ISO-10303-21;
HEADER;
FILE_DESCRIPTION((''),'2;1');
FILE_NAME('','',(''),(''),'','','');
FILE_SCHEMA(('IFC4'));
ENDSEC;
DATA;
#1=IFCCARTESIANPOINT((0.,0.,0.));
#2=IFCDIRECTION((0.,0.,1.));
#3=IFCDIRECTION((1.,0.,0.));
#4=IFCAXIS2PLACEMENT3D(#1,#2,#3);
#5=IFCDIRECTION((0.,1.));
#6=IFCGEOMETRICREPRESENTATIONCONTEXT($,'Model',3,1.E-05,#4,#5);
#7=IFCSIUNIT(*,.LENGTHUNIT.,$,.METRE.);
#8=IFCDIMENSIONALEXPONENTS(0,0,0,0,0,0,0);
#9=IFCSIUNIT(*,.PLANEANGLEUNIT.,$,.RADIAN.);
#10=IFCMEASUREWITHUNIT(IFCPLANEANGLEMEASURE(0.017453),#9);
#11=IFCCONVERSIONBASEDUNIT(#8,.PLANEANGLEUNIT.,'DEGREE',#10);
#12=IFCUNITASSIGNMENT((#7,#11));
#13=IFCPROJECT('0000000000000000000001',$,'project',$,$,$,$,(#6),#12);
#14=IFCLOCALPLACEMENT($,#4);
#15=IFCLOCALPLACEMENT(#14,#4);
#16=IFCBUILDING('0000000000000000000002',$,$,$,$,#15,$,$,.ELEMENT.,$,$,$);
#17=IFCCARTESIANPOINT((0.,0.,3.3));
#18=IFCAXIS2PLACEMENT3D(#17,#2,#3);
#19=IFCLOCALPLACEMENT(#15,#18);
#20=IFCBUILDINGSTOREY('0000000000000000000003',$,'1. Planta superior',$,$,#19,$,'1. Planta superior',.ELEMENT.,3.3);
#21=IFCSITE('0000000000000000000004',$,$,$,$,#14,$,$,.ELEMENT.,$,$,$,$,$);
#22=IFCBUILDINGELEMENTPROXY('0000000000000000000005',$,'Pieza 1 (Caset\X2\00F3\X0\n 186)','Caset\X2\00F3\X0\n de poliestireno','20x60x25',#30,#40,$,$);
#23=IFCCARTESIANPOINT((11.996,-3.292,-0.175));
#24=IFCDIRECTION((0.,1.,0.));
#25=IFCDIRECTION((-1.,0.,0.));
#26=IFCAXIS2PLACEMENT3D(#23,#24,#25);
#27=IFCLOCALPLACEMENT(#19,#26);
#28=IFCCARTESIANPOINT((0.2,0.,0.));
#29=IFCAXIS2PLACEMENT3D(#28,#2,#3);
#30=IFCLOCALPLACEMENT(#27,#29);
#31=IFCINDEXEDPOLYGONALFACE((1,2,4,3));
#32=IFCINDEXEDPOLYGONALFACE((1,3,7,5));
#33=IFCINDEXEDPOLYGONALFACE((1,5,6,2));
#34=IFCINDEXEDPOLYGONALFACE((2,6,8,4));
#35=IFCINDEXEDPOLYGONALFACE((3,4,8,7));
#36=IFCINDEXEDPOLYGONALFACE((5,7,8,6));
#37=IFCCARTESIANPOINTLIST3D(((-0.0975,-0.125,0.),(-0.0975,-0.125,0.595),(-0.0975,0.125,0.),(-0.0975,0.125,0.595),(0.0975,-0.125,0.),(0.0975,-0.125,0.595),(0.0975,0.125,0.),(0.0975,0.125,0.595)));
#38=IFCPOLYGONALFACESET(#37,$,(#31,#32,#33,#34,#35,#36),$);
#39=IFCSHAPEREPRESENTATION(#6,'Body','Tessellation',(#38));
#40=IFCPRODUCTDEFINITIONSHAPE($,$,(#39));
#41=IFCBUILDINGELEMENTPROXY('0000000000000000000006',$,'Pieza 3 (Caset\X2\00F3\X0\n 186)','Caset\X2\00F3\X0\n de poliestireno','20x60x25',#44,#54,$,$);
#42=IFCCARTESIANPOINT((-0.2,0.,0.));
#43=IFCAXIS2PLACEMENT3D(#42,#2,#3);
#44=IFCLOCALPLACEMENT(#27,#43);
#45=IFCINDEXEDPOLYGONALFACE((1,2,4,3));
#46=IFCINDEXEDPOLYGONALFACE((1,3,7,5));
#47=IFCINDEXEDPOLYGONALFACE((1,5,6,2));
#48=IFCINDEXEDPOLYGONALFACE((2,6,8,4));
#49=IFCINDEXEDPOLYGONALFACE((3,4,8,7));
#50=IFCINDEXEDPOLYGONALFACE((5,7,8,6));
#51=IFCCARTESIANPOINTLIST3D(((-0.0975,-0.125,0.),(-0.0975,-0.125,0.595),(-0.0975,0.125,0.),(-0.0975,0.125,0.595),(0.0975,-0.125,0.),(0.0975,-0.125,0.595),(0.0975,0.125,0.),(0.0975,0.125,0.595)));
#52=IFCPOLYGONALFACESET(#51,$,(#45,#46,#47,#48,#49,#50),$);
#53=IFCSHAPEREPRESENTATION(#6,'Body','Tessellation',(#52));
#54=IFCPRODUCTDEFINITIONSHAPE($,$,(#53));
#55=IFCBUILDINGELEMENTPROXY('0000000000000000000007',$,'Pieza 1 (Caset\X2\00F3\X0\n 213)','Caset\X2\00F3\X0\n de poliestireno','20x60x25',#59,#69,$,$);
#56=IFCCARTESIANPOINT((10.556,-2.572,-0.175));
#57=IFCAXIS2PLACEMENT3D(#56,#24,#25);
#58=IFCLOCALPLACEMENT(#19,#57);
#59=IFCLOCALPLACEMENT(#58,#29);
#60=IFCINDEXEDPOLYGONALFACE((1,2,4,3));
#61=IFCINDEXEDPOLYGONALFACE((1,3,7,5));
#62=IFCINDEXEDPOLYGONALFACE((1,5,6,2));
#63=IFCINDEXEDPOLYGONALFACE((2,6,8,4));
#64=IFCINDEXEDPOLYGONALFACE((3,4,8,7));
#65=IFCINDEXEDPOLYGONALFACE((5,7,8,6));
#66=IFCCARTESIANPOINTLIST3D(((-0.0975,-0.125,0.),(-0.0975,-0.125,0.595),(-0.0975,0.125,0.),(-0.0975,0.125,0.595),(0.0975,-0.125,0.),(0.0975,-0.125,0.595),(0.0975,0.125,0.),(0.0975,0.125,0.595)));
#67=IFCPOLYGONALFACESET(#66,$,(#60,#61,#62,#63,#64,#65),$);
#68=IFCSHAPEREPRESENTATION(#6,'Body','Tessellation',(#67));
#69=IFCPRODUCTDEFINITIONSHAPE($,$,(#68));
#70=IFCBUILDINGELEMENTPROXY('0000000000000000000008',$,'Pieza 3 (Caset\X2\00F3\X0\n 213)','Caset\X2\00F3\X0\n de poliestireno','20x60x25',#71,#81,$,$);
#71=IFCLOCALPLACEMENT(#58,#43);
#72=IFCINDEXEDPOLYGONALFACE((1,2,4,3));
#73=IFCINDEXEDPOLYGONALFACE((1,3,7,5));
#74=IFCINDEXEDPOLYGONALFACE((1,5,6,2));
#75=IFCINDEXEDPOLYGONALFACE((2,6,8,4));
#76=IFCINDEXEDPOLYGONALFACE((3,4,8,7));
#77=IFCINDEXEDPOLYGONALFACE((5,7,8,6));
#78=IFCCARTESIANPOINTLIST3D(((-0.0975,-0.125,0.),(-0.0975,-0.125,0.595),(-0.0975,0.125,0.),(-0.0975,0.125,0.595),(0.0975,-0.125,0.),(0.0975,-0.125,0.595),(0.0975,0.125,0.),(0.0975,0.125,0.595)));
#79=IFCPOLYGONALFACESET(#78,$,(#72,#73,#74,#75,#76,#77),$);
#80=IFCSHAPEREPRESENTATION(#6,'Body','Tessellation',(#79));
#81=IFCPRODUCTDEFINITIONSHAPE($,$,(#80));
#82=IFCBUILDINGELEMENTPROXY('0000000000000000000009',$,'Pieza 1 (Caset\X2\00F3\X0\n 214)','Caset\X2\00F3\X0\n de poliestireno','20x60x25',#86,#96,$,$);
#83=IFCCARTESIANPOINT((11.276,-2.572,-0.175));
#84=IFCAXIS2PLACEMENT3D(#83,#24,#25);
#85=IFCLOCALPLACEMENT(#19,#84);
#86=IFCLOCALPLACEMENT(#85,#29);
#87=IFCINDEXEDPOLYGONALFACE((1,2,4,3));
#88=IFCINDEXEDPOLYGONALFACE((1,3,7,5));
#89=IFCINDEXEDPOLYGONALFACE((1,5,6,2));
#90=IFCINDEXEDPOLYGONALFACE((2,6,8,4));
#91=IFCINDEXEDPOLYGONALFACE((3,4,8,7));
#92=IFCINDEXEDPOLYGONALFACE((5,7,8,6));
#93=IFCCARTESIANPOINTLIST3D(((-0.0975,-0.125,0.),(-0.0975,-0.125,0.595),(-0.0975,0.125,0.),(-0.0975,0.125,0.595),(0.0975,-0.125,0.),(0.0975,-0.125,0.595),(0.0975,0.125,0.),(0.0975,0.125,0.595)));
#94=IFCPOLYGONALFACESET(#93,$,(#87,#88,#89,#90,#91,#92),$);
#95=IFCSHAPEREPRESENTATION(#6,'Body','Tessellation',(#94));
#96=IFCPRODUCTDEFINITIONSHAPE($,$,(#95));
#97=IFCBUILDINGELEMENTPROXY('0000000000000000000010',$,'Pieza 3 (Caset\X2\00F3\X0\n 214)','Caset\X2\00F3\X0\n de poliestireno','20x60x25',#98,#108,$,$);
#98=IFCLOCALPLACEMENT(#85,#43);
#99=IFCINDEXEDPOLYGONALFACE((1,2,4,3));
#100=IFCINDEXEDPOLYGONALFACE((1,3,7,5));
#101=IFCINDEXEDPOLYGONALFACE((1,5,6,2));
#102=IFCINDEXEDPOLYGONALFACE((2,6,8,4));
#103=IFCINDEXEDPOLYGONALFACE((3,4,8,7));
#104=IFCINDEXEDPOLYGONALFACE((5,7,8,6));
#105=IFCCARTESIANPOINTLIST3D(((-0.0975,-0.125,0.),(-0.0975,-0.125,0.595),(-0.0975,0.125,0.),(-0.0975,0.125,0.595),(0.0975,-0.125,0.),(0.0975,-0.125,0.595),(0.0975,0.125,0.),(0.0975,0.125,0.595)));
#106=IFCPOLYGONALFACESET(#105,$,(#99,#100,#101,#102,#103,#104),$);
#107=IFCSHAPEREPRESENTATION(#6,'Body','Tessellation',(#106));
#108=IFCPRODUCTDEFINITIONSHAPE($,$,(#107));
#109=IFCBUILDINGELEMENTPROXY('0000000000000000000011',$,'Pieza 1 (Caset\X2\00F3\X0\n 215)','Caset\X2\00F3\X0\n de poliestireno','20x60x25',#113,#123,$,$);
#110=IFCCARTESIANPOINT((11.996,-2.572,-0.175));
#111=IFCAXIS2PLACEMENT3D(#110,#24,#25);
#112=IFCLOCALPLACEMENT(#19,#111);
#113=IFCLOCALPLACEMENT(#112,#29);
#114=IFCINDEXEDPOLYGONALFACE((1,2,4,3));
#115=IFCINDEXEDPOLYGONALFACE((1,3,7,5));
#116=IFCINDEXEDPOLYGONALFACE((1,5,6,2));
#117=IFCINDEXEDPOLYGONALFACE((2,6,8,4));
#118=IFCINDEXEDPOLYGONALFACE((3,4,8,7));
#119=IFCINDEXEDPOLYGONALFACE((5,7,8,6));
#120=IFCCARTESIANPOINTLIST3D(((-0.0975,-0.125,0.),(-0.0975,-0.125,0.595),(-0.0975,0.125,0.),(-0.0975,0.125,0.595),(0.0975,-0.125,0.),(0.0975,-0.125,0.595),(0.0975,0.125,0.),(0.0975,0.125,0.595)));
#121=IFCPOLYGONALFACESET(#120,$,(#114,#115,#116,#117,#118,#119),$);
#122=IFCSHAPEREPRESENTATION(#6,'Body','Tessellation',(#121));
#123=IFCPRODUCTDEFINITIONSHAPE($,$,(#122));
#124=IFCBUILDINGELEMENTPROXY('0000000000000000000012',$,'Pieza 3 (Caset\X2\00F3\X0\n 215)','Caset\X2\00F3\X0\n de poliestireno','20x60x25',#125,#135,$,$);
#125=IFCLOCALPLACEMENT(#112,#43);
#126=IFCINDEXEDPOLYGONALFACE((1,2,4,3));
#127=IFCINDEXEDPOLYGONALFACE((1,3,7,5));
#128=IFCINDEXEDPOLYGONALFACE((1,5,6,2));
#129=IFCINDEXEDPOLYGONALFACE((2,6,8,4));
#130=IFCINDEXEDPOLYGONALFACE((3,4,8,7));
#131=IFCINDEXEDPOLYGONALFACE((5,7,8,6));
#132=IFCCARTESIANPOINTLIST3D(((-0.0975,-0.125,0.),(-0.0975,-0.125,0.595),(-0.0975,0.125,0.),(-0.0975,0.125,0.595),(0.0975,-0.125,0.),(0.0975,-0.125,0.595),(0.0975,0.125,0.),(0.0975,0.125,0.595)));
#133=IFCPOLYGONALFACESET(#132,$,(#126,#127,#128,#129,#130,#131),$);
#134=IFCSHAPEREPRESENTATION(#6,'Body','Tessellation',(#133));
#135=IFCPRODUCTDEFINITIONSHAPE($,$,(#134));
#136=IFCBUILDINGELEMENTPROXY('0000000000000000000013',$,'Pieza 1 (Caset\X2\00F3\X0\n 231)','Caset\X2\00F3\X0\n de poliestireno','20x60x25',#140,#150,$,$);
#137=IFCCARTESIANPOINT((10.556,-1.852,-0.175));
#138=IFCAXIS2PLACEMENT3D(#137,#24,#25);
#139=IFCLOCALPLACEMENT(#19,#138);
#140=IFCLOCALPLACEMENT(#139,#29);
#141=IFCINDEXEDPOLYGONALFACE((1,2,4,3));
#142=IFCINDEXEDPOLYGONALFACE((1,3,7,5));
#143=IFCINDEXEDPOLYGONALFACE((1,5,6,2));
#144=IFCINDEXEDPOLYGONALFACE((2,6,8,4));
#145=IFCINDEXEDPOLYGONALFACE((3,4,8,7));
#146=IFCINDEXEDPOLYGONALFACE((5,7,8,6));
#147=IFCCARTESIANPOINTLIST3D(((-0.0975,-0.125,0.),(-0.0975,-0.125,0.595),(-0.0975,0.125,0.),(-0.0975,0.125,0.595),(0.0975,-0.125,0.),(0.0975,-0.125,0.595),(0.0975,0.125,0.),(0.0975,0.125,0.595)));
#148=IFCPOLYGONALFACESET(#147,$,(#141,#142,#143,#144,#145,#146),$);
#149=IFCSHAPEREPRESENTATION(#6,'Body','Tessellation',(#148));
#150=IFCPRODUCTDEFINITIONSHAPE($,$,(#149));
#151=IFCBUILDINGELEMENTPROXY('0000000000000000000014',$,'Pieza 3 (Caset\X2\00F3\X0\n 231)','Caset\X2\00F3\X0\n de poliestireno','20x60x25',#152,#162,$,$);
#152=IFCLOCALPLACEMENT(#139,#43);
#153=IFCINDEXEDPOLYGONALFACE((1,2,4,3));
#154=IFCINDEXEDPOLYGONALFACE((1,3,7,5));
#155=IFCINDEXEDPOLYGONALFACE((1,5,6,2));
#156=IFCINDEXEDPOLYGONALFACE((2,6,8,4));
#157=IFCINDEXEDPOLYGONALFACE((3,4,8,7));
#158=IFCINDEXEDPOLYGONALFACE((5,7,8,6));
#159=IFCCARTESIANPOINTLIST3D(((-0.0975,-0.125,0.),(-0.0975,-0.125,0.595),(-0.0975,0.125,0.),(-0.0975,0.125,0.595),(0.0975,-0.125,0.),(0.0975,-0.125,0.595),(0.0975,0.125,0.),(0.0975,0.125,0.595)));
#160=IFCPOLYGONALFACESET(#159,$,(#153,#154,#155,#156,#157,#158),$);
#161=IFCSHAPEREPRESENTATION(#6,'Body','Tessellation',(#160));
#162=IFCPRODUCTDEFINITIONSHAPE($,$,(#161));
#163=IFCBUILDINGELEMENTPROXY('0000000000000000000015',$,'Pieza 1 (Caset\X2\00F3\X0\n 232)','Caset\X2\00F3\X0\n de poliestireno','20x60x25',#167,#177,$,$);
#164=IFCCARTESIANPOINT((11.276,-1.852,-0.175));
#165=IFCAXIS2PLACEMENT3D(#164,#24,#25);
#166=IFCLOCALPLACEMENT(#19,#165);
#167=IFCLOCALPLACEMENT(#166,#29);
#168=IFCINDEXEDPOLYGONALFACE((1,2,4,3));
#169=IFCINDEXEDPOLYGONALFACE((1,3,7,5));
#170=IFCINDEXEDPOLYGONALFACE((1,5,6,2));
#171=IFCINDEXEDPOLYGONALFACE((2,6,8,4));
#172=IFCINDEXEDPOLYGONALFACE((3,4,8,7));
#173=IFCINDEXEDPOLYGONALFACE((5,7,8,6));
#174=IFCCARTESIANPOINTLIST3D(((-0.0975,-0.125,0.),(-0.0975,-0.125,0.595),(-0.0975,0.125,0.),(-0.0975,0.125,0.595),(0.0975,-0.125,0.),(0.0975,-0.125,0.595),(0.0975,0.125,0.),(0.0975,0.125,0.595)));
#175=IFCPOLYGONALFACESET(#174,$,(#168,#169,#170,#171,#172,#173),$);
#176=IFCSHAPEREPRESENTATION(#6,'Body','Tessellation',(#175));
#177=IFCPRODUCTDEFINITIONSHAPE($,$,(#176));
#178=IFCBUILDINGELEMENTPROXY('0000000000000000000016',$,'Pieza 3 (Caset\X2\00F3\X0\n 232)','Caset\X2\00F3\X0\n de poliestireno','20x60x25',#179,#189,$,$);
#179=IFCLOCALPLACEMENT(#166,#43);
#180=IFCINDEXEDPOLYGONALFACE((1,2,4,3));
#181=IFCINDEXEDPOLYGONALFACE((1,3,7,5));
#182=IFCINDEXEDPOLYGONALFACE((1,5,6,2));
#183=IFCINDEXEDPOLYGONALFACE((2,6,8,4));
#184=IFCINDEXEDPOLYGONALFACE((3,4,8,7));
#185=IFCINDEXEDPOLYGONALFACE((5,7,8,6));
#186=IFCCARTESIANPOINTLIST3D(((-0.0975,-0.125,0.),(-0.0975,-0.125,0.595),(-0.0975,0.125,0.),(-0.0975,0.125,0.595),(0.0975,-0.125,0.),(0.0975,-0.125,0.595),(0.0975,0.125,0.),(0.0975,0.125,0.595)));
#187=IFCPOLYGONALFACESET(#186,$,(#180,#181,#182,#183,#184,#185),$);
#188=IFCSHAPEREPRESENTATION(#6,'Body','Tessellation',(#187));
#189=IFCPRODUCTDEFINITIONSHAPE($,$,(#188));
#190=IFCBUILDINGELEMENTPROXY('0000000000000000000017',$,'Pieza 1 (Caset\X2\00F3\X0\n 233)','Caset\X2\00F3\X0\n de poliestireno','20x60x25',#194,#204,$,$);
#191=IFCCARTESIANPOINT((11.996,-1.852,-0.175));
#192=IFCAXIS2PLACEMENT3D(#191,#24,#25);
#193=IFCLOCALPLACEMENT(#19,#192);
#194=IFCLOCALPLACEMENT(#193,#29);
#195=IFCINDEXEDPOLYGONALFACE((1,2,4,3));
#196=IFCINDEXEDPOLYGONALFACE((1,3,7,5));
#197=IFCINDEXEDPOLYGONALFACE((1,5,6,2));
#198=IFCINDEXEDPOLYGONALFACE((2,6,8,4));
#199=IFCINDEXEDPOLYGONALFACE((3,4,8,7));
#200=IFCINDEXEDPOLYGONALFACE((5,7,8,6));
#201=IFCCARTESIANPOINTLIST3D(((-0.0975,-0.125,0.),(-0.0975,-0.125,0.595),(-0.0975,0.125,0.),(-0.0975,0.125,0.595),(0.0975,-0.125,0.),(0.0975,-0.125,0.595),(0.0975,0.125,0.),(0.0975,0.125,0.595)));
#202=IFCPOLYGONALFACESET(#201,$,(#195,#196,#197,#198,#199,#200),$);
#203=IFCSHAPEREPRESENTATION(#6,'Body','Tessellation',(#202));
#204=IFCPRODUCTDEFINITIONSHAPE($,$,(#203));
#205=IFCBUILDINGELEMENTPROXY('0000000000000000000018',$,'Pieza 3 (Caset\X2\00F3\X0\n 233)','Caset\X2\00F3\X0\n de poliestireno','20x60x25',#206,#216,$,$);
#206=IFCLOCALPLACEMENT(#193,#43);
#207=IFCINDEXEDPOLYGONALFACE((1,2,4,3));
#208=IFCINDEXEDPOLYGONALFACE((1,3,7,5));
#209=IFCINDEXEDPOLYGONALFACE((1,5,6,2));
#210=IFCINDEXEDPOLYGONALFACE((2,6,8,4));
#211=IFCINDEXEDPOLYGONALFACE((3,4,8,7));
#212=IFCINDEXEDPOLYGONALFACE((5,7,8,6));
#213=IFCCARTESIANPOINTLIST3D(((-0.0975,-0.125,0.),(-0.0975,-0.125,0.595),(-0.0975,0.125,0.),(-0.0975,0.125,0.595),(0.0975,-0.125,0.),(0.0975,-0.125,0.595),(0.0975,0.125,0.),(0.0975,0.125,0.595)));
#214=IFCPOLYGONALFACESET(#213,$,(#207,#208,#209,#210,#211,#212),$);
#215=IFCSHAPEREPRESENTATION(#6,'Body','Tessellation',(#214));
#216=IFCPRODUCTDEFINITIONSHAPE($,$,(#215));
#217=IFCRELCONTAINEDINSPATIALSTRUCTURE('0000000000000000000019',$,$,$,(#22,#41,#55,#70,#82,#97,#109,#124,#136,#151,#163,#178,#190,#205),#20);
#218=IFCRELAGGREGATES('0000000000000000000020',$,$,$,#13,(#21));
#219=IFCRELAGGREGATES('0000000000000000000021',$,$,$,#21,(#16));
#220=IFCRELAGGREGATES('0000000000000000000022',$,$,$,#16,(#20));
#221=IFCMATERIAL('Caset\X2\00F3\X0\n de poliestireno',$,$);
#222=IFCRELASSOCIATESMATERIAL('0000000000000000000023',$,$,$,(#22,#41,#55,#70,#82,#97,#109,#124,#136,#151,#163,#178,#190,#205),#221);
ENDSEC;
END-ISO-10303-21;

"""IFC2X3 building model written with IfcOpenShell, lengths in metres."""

from ifc_helpers import new_model, entity, si_unit, converted_unit, direction, frame, origin_with_axes, origin_2d_with_axis, place, context, project, spatial, rectangle, extrude, source, transform, mapped, material, element, save


model = new_model("IFC2X3")

# Units and contexts
model_context = context("Model", 3, precision=1e-05, world=origin_with_axes(), true_north=direction((0.0, 1.0)))
ifc_project = project(units=[si_unit("LENGTHUNIT", "METRE"), converted_unit("PLANEANGLEUNIT", "DEGREE", entity("IfcPlaneAngleMeasure", 0.017453), si_unit("PLANEANGLEUNIT", "RADIAN"), dimensions=[0, 0, 0, 0, 0, 0, 0])], contexts=[model_context])

# Site, building, storey
site_placement = place(None, origin_with_axes())
site = spatial("IfcSite", under=ifc_project, at=site_placement, CompositionType="ELEMENT")
building_placement = place(site_placement, origin_with_axes())
building = spatial("IfcBuilding", under=site, at=building_placement, CompositionType="ELEMENT")
storey_placement = place(building_placement, frame((0.0, 0.0, 3.3), z_axis=(0.0, 0.0, 1.0), x_axis=(1.0, 0.0, 0.0)))
storey = spatial("IfcBuildingStorey", under=building, at=storey_placement, Name="1. Planta superior", LongName="1. Planta superior", CompositionType="ELEMENT", Elevation=3.3)

# Building element proxies
ifc_material = material(Name="Casetón de poliestireno")
shared_shape = source(origin_with_axes(), model_context, "Body", "SweptSolid", [
    extrude(rectangle(XDim=0.195, YDim=0.25, at=origin_2d_with_axis()), origin_with_axes(), (0.0, 0.0, 1.0), 0.595),
])
placement_1 = place(storey_placement, frame((11.996, -3.292, -0.175), z_axis=(0.0, 1.0, 0.0), x_axis=(-1.0, 0.0, 0.0)))
for number, where, z_axis, x_axis, name in (
    (1, (0.2, 0.0, 0.0), (0.0, 0.0, 1.0), (1.0, 0.0, 0.0), "Pieza 1 (Casetón 186)"),
    (2, (-0.2, 0.0, 0.0), (0.0, 0.0, 1.0), (1.0, 0.0, 0.0), "Pieza 3 (Casetón 186)"),
):
    element("IfcBuildingElementProxy", number, at=place(placement_1, frame(where, z_axis=z_axis, x_axis=x_axis)), inside=storey, material=ifc_material, Name=name, Description="Casetón de poliestireno", ObjectType="20x60x25", context=model_context, shape_type="MappedRepresentation", body=[
        mapped(shared_shape, transform((0.0, 0.0, 0.0), x_axis=(1.0, 0.0, 0.0), y_axis=(0.0, 1.0, 0.0), z_axis=(0.0, 0.0, 1.0))),
    ])
placement_2 = place(storey_placement, frame((10.556, -2.572, -0.175), z_axis=(0.0, 1.0, 0.0), x_axis=(-1.0, 0.0, 0.0)))
for number, where, z_axis, x_axis, name in (
    (3, (0.2, 0.0, 0.0), (0.0, 0.0, 1.0), (1.0, 0.0, 0.0), "Pieza 1 (Casetón 213)"),
    (4, (-0.2, 0.0, 0.0), (0.0, 0.0, 1.0), (1.0, 0.0, 0.0), "Pieza 3 (Casetón 213)"),
):
    element("IfcBuildingElementProxy", number, at=place(placement_2, frame(where, z_axis=z_axis, x_axis=x_axis)), inside=storey, material=ifc_material, Name=name, Description="Casetón de poliestireno", ObjectType="20x60x25", context=model_context, shape_type="MappedRepresentation", body=[
        mapped(shared_shape, transform((0.0, 0.0, 0.0), x_axis=(1.0, 0.0, 0.0), y_axis=(0.0, 1.0, 0.0), z_axis=(0.0, 0.0, 1.0))),
    ])
placement_3 = place(storey_placement, frame((11.276, -2.572, -0.175), z_axis=(0.0, 1.0, 0.0), x_axis=(-1.0, 0.0, 0.0)))
for number, where, z_axis, x_axis, name in (
    (5, (0.2, 0.0, 0.0), (0.0, 0.0, 1.0), (1.0, 0.0, 0.0), "Pieza 1 (Casetón 214)"),
    (6, (-0.2, 0.0, 0.0), (0.0, 0.0, 1.0), (1.0, 0.0, 0.0), "Pieza 3 (Casetón 214)"),
):
    element("IfcBuildingElementProxy", number, at=place(placement_3, frame(where, z_axis=z_axis, x_axis=x_axis)), inside=storey, material=ifc_material, Name=name, Description="Casetón de poliestireno", ObjectType="20x60x25", context=model_context, shape_type="MappedRepresentation", body=[
        mapped(shared_shape, transform((0.0, 0.0, 0.0), x_axis=(1.0, 0.0, 0.0), y_axis=(0.0, 1.0, 0.0), z_axis=(0.0, 0.0, 1.0))),
    ])
placement_4 = place(storey_placement, frame((11.996, -2.572, -0.175), z_axis=(0.0, 1.0, 0.0), x_axis=(-1.0, 0.0, 0.0)))
for number, where, z_axis, x_axis, name in (
    (7, (0.2, 0.0, 0.0), (0.0, 0.0, 1.0), (1.0, 0.0, 0.0), "Pieza 1 (Casetón 215)"),
    (8, (-0.2, 0.0, 0.0), (0.0, 0.0, 1.0), (1.0, 0.0, 0.0), "Pieza 3 (Casetón 215)"),
):
    element("IfcBuildingElementProxy", number, at=place(placement_4, frame(where, z_axis=z_axis, x_axis=x_axis)), inside=storey, material=ifc_material, Name=name, Description="Casetón de poliestireno", ObjectType="20x60x25", context=model_context, shape_type="MappedRepresentation", body=[
        mapped(shared_shape, transform((0.0, 0.0, 0.0), x_axis=(1.0, 0.0, 0.0), y_axis=(0.0, 1.0, 0.0), z_axis=(0.0, 0.0, 1.0))),
    ])
placement_5 = place(storey_placement, frame((10.556, -1.852, -0.175), z_axis=(0.0, 1.0, 0.0), x_axis=(-1.0, 0.0, 0.0)))
for number, where, z_axis, x_axis, name in (
    (9, (0.2, 0.0, 0.0), (0.0, 0.0, 1.0), (1.0, 0.0, 0.0), "Pieza 1 (Casetón 231)"),
    (10, (-0.2, 0.0, 0.0), (0.0, 0.0, 1.0), (1.0, 0.0, 0.0), "Pieza 3 (Casetón 231)"),
):
    element("IfcBuildingElementProxy", number, at=place(placement_5, frame(where, z_axis=z_axis, x_axis=x_axis)), inside=storey, material=ifc_material, Name=name, Description="Casetón de poliestireno", ObjectType="20x60x25", context=model_context, shape_type="MappedRepresentation", body=[
        mapped(shared_shape, transform((0.0, 0.0, 0.0), x_axis=(1.0, 0.0, 0.0), y_axis=(0.0, 1.0, 0.0), z_axis=(0.0, 0.0, 1.0))),
    ])
placement_6 = place(storey_placement, frame((11.276, -1.852, -0.175), z_axis=(0.0, 1.0, 0.0), x_axis=(-1.0, 0.0, 0.0)))
for number, where, z_axis, x_axis, name in (
    (11, (0.2, 0.0, 0.0), (0.0, 0.0, 1.0), (1.0, 0.0, 0.0), "Pieza 1 (Casetón 232)"),
    (12, (-0.2, 0.0, 0.0), (0.0, 0.0, 1.0), (1.0, 0.0, 0.0), "Pieza 3 (Casetón 232)"),
):
    element("IfcBuildingElementProxy", number, at=place(placement_6, frame(where, z_axis=z_axis, x_axis=x_axis)), inside=storey, material=ifc_material, Name=name, Description="Casetón de poliestireno", ObjectType="20x60x25", context=model_context, shape_type="MappedRepresentation", body=[
        mapped(shared_shape, transform((0.0, 0.0, 0.0), x_axis=(1.0, 0.0, 0.0), y_axis=(0.0, 1.0, 0.0), z_axis=(0.0, 0.0, 1.0))),
    ])
placement_7 = place(storey_placement, frame((11.996, -1.852, -0.175), z_axis=(0.0, 1.0, 0.0), x_axis=(-1.0, 0.0, 0.0)))
for number, where, z_axis, x_axis, name in (
    (13, (0.2, 0.0, 0.0), (0.0, 0.0, 1.0), (1.0, 0.0, 0.0), "Pieza 1 (Casetón 233)"),
    (14, (-0.2, 0.0, 0.0), (0.0, 0.0, 1.0), (1.0, 0.0, 0.0), "Pieza 3 (Casetón 233)"),
):
    element("IfcBuildingElementProxy", number, at=place(placement_7, frame(where, z_axis=z_axis, x_axis=x_axis)), inside=storey, material=ifc_material, Name=name, Description="Casetón de poliestireno", ObjectType="20x60x25", context=model_context, shape_type="MappedRepresentation", body=[
        mapped(shared_shape, transform((0.0, 0.0, 0.0), x_axis=(1.0, 0.0, 0.0), y_axis=(0.0, 1.0, 0.0), z_axis=(0.0, 0.0, 1.0))),
    ])

save(model, "model.ifc")
